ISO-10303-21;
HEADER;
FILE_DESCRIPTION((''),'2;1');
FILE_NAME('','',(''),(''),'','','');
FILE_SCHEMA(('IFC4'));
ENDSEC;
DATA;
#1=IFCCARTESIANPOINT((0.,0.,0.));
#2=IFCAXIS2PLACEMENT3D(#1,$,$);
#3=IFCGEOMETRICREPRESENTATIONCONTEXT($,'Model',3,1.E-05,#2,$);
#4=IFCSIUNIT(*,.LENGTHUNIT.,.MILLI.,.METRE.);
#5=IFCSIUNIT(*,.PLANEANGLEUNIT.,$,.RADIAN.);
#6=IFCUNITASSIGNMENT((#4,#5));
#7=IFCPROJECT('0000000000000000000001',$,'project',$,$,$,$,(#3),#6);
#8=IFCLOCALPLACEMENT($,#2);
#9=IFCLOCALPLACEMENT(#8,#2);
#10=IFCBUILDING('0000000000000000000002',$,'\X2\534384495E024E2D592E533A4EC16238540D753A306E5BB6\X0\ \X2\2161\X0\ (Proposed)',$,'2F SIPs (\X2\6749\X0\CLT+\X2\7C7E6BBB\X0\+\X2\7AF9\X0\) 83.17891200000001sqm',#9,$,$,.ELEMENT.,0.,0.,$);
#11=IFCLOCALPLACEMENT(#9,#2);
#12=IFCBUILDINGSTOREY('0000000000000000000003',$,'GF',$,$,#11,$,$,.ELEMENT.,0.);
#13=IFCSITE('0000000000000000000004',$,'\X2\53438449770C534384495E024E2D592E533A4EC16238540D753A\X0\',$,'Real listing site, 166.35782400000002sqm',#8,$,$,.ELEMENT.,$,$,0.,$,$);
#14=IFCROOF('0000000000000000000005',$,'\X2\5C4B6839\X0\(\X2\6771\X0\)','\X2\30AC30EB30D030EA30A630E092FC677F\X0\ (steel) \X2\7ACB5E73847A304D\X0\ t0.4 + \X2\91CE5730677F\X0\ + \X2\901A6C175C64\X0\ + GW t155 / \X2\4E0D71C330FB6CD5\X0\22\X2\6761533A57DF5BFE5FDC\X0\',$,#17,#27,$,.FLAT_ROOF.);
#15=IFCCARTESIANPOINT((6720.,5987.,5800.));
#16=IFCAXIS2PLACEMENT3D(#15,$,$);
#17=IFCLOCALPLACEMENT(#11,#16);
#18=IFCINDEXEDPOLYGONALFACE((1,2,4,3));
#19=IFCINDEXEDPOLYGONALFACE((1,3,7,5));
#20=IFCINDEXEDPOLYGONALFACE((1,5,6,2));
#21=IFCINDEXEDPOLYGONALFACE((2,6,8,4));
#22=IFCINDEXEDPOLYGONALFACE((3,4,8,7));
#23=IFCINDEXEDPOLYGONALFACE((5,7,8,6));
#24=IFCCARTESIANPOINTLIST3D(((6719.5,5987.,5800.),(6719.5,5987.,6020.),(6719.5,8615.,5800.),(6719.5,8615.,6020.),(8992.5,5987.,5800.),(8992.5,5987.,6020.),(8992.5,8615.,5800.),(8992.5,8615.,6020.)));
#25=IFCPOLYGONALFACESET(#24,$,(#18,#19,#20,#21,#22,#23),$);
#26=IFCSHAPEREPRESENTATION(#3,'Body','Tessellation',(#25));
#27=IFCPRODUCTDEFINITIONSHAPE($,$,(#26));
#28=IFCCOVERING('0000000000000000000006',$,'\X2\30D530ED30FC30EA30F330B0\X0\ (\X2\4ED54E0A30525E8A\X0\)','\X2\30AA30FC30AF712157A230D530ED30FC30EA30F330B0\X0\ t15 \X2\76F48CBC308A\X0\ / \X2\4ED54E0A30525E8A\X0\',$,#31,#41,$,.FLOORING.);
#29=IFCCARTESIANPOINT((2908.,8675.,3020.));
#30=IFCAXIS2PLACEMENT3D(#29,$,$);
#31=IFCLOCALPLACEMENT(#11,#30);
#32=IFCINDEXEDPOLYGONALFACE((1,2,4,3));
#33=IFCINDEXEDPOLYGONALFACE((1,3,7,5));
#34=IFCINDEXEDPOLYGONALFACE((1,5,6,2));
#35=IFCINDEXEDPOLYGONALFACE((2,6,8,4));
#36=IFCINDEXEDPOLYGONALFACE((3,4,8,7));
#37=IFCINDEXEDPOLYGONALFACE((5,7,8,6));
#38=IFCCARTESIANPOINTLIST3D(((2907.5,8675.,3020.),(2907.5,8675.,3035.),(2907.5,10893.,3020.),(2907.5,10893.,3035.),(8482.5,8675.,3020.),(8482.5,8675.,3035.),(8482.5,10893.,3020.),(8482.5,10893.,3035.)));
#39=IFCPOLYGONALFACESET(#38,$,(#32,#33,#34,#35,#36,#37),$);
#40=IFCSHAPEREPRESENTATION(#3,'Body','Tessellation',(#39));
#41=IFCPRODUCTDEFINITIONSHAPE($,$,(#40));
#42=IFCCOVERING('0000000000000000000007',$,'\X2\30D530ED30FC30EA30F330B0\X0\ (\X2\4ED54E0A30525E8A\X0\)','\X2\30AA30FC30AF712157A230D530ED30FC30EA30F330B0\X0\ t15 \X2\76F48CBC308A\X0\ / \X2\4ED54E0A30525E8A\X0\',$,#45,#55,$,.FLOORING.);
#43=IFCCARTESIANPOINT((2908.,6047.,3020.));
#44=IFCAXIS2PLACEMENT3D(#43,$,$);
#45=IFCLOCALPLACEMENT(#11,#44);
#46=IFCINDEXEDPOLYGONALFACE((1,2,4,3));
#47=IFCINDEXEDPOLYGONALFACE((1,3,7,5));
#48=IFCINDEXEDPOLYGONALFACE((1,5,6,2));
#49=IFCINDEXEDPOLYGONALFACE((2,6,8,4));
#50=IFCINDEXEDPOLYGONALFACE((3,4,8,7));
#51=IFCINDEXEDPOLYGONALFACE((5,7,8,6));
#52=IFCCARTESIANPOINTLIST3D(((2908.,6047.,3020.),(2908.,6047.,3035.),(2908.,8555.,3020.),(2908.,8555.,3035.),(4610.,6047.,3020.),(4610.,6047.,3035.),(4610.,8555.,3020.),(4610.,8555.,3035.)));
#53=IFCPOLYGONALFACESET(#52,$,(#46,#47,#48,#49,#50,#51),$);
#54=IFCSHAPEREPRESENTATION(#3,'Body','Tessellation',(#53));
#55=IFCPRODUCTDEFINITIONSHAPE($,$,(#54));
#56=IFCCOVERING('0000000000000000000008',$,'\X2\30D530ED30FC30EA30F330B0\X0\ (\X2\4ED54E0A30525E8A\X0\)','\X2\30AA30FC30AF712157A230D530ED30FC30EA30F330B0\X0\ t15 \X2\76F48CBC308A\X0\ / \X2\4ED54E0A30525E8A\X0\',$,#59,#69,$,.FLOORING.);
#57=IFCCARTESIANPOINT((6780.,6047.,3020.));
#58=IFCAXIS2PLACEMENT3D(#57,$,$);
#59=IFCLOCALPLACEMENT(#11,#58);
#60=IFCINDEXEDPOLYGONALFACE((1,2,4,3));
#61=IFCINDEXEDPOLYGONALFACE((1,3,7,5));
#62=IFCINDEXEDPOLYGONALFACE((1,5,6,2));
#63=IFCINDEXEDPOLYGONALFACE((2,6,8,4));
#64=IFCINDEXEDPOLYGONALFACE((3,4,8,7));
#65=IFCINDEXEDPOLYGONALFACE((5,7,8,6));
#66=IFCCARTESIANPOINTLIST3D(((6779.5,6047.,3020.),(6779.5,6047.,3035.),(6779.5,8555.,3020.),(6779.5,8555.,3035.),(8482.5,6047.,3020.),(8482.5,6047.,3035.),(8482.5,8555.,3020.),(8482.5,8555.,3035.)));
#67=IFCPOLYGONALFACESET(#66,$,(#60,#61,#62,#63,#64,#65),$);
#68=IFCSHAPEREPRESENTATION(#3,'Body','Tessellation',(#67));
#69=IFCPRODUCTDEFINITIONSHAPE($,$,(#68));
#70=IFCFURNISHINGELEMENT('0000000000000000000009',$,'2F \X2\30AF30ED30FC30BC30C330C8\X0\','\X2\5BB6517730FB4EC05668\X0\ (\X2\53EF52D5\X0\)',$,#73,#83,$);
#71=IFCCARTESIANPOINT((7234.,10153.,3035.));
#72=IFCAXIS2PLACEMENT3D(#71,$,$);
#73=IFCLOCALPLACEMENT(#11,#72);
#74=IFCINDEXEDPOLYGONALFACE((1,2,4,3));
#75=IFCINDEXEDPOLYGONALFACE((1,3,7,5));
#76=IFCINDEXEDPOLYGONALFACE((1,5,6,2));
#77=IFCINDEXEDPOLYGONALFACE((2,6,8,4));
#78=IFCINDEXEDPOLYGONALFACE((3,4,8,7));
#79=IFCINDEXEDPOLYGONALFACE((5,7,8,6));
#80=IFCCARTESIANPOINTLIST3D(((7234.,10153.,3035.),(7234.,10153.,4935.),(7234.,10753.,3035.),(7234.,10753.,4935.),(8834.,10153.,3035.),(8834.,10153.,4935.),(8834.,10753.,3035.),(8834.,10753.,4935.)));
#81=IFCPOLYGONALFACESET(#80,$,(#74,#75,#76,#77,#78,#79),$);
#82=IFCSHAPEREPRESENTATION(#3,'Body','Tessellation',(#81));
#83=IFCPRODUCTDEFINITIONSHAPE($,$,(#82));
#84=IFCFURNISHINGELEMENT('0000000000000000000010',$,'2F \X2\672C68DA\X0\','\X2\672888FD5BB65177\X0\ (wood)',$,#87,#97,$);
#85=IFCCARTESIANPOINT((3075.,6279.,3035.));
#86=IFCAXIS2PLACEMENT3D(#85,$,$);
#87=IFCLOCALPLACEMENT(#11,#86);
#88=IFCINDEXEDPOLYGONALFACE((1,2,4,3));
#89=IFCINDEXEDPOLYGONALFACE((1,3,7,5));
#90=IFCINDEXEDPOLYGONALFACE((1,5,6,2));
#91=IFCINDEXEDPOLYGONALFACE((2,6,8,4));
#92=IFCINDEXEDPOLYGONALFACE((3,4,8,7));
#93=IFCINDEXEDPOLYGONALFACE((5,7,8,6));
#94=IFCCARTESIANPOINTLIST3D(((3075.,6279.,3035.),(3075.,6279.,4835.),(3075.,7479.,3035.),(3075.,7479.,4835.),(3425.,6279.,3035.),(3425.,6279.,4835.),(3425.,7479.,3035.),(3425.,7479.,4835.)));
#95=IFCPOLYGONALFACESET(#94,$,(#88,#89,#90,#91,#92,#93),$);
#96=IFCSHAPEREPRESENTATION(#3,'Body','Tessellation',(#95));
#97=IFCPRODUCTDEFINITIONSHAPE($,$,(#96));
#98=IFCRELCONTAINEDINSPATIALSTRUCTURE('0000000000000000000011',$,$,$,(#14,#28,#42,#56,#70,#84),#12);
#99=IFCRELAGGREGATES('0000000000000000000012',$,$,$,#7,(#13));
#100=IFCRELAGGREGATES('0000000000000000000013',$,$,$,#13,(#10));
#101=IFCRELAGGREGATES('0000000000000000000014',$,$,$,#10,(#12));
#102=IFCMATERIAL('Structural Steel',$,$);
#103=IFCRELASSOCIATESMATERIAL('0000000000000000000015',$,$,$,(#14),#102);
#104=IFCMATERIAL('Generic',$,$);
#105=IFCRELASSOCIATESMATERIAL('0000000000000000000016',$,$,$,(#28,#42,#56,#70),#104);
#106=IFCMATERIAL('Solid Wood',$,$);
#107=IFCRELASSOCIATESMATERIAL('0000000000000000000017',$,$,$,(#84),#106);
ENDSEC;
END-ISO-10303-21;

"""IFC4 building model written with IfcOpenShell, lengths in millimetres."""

from ifc_helpers import new_model, si_unit, frame, frame_2d, origin, place, context, project, spatial, rectangle, extrude, material, element, save


model = new_model("IFC4")

# Units and contexts
model_context = context("Model", 3, precision=1e-05, world=origin())
ifc_project = project(units=[si_unit("LENGTHUNIT", "METRE", prefix="MILLI"), si_unit("PLANEANGLEUNIT", "RADIAN")], contexts=[model_context])

# Site, building, storey
site_placement = place(None, origin())
site = spatial("IfcSite", under=ifc_project, at=site_placement, Name="千葉県千葉市中央区仁戸名町", ObjectType="Real listing site, 166.35782400000002sqm", CompositionType="ELEMENT", RefElevation=0.0)
building_placement = place(site_placement, origin())
building = spatial("IfcBuilding", under=site, at=building_placement, Name="千葉市中央区仁戸名町の家 Ⅱ (Proposed)", ObjectType="2F SIPs (杉CLT+籾殻+竹) 83.17891200000001sqm", CompositionType="ELEMENT", ElevationOfRefHeight=0.0, ElevationOfTerrain=0.0)
storey_placement = place(building_placement, origin())
storey = spatial("IfcBuildingStorey", under=building, at=storey_placement, Name="GF", CompositionType="ELEMENT", Elevation=0.0)

# Shared definitions
ifc_material_1 = material(Name="Solid Wood")

# Roof
ifc_material_2 = material(Name="Structural Steel")
roof_1_placement = place(storey_placement, frame((6720.0, 5987.0, 5800.0)))
element("IfcRoof", 1, at=roof_1_placement, inside=storey, material=ifc_material_2, Name="屋根(東)", Description="ガルバリウム鋼板 (steel) 立平葺き t0.4 + 野地板 + 通気層 + GW t155 / 不燃・法22条区域対応", PredefinedType="FLAT_ROOF", context=model_context, shape_type="SweptSolid", body=[
    extrude(rectangle(XDim=2273.0, YDim=2628.0, at=frame_2d((1136.0, 1314.0))), frame((6720.0, 5987.0, 5800.0)), (0.0, 0.0, 1.0), 220.0),
])

# Coverings
ifc_material_3 = material(Name="Generic")
covering_1_placement = place(storey_placement, frame((2908.0, 8675.0, 3020.0)))
element("IfcCovering", 2, at=covering_1_placement, inside=storey, material=ifc_material_3, Name="フローリング (仕上げ床)", Description="オーク無垢フローリング t15 直貼り / 仕上げ床", PredefinedType="FLOORING", context=model_context, shape_type="SweptSolid", body=[
    extrude(rectangle(XDim=5575.0, YDim=2218.0, at=frame_2d((2787.0, 1109.0))), frame((2908.0, 8675.0, 3020.0)), (0.0, 0.0, 1.0), 15.0),
])
covering_2_placement = place(storey_placement, frame((2908.0, 6047.0, 3020.0)))
element("IfcCovering", 3, at=covering_2_placement, inside=storey, material=ifc_material_3, Name="フローリング (仕上げ床)", Description="オーク無垢フローリング t15 直貼り / 仕上げ床", PredefinedType="FLOORING", context=model_context, shape_type="SweptSolid", body=[
    extrude(rectangle(XDim=1702.0, YDim=2508.0, at=frame_2d((851.0, 1254.0))), frame((2908.0, 6047.0, 3020.0)), (0.0, 0.0, 1.0), 15.0),
])
covering_3_placement = place(storey_placement, frame((6780.0, 6047.0, 3020.0)))
element("IfcCovering", 4, at=covering_3_placement, inside=storey, material=ifc_material_3, Name="フローリング (仕上げ床)", Description="オーク無垢フローリング t15 直貼り / 仕上げ床", PredefinedType="FLOORING", context=model_context, shape_type="SweptSolid", body=[
    extrude(rectangle(XDim=1703.0, YDim=2508.0, at=frame_2d((851.0, 1254.0))), frame((6780.0, 6047.0, 3020.0)), (0.0, 0.0, 1.0), 15.0),
])

# Furnishing elements
furnishing_1_placement = place(storey_placement, frame((7234.0, 10153.0, 3035.0)))
element("IfcFurnishingElement", 5, at=furnishing_1_placement, inside=storey, material=ifc_material_3, Name="2F クローゼット", Description="家具・什器 (可動)", context=model_context, shape_type="SweptSolid", body=[
    extrude(rectangle(XDim=1600.0, YDim=600.0, at=frame_2d((800.0, 300.0))), frame((7234.0, 10153.0, 3035.0)), (0.0, 0.0, 1.0), 1900.0),
])
furnishing_2_placement = place(storey_placement, frame((3075.0, 6279.0, 3035.0)))
element("IfcFurnishingElement", 6, at=furnishing_2_placement, inside=storey, material=ifc_material_1, Name="2F 本棚", Description="木製家具 (wood)", context=model_context, shape_type="SweptSolid", body=[
    extrude(rectangle(XDim=350.0, YDim=1200.0, at=frame_2d((175.0, 600.0))), frame((3075.0, 6279.0, 3035.0)), (0.0, 0.0, 1.0), 1800.0),
])

save(model, "model.ifc")
